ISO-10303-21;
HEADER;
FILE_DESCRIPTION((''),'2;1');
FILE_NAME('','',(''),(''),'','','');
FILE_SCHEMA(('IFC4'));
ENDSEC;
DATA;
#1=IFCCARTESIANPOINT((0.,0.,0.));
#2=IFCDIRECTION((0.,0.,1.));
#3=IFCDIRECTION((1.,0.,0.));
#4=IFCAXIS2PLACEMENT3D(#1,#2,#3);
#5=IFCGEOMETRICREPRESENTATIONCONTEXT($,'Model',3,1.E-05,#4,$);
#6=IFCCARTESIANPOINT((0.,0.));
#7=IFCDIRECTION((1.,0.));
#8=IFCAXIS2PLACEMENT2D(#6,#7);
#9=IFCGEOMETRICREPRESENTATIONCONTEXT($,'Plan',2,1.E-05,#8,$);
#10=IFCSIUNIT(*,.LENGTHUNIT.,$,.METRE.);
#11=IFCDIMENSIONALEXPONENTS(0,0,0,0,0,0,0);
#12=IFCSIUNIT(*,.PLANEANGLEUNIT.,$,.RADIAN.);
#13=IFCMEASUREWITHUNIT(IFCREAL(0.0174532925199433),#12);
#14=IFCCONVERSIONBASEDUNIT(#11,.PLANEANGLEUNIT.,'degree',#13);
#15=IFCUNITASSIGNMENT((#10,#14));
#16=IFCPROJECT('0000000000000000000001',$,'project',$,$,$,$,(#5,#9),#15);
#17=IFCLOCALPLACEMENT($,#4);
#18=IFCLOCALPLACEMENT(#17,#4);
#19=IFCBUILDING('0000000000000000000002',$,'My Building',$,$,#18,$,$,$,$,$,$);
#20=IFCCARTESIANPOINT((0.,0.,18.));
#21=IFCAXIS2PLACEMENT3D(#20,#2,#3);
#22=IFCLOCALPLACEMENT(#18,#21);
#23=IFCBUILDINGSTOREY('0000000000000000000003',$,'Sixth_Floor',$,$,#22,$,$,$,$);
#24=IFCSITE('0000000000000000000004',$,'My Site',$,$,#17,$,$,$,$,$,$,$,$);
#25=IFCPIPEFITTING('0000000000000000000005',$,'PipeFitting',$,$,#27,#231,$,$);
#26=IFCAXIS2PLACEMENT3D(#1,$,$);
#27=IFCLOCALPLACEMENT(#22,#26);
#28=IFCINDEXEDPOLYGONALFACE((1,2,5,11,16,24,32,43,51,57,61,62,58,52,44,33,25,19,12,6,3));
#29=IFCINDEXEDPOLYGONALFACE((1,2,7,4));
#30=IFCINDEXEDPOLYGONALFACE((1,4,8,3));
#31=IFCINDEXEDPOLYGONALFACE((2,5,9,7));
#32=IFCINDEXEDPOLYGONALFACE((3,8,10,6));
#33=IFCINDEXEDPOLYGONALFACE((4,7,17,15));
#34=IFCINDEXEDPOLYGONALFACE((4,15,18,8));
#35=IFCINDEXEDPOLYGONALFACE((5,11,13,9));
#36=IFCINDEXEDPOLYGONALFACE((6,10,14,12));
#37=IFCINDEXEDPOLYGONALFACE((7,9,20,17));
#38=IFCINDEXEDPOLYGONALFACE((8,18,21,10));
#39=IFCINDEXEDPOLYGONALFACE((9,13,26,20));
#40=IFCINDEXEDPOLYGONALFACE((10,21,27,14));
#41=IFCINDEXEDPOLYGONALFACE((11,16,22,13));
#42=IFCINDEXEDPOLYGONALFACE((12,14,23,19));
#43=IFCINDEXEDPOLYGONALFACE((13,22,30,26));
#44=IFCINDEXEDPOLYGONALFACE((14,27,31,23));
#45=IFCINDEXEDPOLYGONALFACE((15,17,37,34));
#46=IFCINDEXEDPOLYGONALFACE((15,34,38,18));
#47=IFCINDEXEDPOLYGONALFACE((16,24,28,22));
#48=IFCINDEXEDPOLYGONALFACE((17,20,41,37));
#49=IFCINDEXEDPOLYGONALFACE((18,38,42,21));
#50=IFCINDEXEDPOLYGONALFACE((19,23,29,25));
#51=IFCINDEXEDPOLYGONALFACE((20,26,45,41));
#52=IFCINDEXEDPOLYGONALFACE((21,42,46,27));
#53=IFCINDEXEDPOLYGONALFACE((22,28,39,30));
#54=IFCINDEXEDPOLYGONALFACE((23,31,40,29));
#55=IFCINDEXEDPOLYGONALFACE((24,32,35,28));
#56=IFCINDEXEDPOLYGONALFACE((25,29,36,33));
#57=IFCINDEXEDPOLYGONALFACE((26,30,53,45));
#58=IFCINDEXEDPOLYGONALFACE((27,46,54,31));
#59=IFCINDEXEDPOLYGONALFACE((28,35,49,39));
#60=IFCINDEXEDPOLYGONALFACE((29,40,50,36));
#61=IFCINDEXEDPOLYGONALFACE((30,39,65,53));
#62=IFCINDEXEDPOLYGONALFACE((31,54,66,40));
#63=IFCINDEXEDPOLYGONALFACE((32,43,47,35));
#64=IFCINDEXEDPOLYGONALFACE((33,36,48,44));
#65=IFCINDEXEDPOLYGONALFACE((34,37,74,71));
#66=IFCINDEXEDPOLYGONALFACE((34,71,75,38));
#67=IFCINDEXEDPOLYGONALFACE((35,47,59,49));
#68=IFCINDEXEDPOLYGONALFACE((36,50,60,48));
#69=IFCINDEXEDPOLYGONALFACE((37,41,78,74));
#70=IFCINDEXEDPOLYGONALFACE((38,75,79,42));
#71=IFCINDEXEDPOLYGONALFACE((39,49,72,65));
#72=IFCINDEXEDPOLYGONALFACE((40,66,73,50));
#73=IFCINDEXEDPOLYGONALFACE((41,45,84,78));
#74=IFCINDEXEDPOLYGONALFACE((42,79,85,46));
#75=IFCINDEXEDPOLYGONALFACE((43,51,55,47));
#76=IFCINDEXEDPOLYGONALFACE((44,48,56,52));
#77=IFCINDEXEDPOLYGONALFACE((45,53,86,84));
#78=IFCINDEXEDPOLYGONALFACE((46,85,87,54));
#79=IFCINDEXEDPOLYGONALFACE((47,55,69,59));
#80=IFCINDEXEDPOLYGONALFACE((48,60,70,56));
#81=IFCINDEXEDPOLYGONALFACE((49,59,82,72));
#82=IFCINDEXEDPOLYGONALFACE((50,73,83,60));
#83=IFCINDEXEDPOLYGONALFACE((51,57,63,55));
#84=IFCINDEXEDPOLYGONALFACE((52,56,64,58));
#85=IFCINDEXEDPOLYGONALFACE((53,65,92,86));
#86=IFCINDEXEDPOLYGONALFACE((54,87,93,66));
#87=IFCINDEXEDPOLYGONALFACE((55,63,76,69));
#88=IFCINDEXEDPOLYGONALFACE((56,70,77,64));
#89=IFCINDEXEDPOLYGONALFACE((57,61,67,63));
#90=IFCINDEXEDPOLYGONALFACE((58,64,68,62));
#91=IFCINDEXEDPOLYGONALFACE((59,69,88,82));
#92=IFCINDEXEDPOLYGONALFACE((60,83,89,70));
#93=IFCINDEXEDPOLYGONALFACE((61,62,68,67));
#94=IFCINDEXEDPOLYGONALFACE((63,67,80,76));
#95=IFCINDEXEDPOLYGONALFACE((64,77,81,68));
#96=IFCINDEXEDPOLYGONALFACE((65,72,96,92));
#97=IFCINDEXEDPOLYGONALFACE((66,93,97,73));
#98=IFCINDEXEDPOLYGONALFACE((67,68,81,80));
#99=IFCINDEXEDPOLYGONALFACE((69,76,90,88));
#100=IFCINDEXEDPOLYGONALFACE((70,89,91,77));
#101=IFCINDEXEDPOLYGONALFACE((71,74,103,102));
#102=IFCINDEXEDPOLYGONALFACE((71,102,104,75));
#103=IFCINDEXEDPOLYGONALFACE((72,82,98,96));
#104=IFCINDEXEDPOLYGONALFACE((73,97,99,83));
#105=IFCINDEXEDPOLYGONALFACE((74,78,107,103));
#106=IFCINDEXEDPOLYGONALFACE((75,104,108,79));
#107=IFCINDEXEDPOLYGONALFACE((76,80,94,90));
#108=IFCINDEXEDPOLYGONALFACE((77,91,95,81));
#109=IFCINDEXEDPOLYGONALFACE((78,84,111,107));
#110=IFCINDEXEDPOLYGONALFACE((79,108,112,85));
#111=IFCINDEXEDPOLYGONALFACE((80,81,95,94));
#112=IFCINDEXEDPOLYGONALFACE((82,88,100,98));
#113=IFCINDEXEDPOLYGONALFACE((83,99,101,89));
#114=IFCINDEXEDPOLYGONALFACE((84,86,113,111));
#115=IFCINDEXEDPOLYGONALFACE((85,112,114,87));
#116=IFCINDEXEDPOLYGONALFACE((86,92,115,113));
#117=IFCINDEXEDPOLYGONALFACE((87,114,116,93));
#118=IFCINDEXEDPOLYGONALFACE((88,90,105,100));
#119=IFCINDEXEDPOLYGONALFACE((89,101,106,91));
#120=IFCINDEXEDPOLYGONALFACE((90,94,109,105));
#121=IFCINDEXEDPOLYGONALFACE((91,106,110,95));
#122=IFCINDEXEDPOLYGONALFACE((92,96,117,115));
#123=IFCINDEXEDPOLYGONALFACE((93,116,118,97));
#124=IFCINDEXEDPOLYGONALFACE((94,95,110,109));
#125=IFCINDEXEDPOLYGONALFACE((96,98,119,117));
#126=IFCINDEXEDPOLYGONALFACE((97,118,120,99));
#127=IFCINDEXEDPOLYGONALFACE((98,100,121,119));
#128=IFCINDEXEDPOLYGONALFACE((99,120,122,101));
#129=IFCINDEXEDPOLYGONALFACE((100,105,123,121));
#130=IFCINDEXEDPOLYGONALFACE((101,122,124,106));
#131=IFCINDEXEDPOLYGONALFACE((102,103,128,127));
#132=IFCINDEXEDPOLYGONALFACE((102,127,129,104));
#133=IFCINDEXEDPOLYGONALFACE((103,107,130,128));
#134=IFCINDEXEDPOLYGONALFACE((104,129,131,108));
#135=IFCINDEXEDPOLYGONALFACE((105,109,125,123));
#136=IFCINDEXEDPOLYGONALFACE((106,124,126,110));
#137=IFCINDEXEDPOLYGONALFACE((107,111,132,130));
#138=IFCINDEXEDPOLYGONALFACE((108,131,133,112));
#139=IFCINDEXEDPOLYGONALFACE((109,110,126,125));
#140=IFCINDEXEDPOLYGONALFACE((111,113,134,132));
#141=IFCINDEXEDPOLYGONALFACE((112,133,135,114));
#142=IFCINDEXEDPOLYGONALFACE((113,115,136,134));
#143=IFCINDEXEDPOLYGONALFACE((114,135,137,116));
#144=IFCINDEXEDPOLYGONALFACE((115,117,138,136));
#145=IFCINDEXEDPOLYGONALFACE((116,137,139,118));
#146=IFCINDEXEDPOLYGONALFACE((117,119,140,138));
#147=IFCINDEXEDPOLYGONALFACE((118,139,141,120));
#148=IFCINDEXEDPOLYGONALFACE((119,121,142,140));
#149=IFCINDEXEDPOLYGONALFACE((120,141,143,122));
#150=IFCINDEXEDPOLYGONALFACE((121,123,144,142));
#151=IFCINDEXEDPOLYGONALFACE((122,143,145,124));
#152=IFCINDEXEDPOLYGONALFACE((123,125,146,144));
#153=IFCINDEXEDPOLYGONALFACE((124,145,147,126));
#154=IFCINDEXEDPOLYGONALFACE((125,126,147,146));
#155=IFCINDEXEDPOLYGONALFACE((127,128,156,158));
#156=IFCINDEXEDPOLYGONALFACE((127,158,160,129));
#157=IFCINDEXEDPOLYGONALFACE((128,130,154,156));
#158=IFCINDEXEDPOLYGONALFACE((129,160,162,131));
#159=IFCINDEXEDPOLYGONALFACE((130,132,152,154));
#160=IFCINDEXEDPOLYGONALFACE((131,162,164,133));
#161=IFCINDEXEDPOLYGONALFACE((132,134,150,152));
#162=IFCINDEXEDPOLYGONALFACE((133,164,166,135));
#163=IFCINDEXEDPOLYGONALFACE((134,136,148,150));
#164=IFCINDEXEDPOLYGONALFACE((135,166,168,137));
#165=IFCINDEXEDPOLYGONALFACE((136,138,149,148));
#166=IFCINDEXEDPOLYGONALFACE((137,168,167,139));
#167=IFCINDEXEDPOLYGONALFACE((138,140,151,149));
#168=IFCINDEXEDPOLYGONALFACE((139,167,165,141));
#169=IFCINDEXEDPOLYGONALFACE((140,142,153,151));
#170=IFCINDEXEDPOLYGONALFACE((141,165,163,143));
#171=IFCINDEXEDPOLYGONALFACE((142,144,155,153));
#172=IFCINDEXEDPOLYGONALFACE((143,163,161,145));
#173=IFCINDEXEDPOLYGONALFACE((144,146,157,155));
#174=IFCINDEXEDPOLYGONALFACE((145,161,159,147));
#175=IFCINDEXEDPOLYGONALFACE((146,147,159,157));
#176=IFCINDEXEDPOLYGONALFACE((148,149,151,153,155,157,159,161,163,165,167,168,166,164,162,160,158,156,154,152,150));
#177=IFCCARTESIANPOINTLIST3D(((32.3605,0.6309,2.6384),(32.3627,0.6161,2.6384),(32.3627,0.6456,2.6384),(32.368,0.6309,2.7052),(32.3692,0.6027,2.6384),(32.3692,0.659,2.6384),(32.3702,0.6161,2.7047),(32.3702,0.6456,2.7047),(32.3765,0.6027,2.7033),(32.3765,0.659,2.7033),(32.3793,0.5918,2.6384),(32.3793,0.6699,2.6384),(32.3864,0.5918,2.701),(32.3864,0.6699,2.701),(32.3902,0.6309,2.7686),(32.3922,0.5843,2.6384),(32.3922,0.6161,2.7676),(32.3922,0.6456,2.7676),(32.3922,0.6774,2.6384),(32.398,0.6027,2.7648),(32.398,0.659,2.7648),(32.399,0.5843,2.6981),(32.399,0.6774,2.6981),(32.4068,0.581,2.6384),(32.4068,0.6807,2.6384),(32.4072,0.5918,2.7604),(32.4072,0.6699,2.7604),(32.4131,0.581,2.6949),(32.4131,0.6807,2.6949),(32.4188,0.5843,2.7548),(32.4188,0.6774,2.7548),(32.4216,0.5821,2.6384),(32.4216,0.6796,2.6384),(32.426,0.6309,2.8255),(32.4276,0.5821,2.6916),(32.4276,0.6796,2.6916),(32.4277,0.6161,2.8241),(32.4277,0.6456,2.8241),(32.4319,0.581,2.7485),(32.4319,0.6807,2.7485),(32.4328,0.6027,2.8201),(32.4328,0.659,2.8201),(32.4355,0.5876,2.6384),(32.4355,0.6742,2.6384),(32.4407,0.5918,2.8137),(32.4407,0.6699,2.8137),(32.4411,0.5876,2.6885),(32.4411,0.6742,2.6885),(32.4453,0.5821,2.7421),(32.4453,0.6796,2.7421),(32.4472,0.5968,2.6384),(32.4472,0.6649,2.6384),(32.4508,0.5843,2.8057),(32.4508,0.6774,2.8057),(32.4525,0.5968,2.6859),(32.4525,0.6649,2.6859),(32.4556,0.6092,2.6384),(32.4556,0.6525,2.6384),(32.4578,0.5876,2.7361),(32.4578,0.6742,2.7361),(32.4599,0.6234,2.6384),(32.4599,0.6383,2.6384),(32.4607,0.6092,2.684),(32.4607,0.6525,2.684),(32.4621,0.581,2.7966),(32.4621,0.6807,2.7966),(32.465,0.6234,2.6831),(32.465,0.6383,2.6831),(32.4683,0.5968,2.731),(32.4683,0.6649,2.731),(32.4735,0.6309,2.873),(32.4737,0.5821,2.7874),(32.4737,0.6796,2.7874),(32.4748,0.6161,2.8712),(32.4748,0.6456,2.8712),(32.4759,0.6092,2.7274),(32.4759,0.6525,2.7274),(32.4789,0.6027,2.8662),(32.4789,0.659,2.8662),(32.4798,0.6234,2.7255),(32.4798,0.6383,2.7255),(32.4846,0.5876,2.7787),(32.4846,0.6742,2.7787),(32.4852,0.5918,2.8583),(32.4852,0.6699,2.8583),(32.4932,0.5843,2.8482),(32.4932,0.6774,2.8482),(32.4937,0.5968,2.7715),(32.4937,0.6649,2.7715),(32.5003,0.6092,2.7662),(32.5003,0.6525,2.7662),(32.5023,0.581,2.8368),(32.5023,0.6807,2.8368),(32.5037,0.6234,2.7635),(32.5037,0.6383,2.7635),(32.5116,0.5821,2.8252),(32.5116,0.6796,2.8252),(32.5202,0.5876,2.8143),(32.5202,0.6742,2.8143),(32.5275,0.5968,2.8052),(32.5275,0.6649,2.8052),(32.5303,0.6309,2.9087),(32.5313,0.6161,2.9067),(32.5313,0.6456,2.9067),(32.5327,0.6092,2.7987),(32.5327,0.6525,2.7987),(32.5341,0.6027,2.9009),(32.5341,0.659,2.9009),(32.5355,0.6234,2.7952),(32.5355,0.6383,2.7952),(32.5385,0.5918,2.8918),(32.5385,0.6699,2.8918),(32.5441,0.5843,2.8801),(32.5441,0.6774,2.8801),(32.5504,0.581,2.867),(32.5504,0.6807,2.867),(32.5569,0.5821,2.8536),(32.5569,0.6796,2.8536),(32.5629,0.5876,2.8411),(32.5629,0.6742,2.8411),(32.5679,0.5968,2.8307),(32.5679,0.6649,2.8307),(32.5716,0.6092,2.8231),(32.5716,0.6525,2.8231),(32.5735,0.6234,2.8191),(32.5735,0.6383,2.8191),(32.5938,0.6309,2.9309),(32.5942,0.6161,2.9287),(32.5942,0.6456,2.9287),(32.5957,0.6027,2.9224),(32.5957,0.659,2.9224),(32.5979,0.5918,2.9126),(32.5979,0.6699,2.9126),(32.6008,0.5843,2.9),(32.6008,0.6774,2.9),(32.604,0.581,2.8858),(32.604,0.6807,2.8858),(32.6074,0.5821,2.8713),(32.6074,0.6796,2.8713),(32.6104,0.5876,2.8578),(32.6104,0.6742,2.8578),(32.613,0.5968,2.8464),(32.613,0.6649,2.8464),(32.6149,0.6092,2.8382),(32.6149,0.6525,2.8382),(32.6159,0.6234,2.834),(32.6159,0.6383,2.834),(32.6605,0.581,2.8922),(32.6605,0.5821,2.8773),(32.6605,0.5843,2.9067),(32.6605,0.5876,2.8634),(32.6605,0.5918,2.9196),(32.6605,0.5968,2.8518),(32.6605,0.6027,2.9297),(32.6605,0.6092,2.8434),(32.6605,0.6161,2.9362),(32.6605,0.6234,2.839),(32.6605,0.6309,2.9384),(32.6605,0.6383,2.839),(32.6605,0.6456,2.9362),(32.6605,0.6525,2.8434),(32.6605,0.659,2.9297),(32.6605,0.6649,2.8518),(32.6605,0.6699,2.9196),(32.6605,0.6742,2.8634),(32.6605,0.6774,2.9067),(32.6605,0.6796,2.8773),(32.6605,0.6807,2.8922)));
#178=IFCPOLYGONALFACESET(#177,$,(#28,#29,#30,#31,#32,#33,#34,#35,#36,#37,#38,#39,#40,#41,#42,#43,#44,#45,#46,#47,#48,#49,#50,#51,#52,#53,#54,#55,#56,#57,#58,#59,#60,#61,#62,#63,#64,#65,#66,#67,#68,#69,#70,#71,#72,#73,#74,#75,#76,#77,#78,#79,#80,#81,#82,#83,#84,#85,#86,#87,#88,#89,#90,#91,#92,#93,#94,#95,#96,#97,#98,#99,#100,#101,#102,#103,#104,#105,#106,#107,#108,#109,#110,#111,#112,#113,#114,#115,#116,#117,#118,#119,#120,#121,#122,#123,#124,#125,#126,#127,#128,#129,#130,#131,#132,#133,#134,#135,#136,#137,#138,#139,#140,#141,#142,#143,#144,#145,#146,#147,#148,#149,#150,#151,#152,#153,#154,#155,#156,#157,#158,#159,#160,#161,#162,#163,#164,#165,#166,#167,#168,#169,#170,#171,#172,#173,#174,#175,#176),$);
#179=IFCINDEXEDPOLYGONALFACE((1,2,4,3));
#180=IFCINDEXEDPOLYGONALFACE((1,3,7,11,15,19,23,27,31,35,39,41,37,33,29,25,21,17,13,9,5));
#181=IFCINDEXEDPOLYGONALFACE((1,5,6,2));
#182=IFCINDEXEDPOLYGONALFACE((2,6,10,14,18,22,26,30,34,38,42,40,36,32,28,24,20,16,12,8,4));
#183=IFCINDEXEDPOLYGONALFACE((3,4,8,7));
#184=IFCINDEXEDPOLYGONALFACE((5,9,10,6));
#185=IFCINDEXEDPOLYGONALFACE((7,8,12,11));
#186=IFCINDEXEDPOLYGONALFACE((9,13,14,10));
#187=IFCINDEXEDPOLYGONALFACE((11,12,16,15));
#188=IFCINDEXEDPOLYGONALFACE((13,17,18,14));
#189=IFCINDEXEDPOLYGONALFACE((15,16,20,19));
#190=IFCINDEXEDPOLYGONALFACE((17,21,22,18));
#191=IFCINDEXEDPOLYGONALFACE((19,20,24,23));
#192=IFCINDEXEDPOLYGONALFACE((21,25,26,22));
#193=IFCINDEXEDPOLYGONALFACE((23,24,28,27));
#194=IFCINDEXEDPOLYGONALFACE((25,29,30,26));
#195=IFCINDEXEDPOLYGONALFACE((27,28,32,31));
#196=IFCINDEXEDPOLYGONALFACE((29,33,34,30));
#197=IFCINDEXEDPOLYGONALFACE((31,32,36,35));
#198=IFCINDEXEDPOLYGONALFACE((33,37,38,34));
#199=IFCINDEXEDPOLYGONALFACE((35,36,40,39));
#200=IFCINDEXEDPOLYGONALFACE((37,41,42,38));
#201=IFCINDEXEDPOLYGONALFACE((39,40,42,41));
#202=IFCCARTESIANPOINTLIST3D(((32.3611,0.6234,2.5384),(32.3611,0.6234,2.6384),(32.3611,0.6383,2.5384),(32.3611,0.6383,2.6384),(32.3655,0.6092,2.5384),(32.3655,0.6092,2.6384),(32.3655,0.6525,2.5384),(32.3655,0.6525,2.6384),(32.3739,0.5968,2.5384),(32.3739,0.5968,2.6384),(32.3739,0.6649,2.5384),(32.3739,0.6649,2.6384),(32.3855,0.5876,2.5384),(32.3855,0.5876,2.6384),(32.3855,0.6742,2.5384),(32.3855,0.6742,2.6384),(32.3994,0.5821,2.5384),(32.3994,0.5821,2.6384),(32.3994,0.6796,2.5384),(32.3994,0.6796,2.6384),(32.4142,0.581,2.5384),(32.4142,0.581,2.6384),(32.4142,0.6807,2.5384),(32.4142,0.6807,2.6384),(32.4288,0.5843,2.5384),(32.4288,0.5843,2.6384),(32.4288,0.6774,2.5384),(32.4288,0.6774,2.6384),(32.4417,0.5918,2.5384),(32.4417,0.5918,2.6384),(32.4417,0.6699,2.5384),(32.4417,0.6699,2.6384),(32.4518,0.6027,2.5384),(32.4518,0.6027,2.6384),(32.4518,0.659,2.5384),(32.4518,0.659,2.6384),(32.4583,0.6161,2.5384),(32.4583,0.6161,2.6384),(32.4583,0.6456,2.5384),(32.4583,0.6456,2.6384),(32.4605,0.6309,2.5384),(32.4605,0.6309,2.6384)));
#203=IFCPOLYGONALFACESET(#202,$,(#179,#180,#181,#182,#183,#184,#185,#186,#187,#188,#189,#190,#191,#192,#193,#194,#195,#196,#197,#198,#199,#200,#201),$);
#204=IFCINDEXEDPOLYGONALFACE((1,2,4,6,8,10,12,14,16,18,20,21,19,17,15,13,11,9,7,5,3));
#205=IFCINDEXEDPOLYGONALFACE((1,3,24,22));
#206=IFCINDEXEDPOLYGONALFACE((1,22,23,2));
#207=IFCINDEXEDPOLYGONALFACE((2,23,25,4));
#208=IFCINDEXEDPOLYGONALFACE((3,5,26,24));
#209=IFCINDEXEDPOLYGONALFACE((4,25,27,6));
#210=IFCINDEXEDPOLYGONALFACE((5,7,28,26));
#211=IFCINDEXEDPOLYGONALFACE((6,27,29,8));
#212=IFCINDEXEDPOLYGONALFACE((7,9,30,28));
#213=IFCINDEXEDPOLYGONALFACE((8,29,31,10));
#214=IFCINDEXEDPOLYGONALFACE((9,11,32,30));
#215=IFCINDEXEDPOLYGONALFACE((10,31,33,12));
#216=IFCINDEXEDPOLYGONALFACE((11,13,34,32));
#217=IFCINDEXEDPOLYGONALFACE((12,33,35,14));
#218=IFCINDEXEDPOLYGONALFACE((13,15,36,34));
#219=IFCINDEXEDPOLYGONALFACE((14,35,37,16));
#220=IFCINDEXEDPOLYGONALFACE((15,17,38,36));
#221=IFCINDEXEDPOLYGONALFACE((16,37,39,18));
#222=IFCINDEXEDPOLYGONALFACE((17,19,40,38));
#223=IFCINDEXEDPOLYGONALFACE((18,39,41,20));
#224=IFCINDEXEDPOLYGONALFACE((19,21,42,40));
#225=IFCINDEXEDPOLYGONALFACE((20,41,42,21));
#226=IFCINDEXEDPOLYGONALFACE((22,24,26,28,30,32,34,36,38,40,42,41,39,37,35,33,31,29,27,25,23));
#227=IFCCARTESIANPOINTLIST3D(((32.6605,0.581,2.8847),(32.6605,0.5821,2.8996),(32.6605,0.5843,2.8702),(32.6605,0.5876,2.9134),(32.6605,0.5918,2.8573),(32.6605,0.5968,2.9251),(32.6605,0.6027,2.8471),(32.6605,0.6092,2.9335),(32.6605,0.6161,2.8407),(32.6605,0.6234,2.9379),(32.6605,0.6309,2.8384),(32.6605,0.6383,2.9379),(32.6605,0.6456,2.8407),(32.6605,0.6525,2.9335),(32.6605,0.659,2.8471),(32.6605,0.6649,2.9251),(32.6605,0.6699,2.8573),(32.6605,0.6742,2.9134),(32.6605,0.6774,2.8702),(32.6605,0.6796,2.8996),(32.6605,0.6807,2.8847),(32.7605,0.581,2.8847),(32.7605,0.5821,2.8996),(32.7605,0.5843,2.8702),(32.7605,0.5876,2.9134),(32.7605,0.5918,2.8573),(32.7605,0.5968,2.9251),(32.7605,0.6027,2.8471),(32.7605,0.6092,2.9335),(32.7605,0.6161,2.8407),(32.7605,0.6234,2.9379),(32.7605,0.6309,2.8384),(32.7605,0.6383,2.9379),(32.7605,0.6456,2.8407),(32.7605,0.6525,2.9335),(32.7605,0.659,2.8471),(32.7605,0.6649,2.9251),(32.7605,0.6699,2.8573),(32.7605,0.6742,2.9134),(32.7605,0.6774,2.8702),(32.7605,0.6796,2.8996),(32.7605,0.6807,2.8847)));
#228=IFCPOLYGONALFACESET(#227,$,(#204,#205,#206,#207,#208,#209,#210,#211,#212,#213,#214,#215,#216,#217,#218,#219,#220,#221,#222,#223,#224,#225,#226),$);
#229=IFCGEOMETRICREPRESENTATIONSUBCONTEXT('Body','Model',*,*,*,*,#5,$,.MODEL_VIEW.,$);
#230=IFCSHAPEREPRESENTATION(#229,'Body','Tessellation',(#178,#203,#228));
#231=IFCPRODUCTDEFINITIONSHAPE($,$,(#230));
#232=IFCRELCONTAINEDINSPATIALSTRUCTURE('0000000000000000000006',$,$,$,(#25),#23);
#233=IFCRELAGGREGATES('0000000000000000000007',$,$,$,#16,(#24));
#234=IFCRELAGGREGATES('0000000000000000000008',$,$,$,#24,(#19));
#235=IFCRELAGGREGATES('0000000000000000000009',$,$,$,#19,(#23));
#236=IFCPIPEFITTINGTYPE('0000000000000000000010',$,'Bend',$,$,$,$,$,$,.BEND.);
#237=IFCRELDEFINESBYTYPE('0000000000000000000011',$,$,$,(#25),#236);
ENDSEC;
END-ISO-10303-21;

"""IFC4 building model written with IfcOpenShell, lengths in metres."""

from ifc_helpers import new_model, entity, si_unit, converted_unit, frame, origin_with_axes, origin_2d_with_axis, place, context, subcontext, project, spatial, circle, extrude, source, transform, mapped, type_object, type_shapes, element, save


model = new_model("IFC4")

# Units and contexts
model_context = context("Model", 3, precision=1e-05, world=origin_with_axes())
plan_context = context("Plan", 2, precision=1e-05, world=origin_2d_with_axis())
body_context = subcontext(model_context, "Body", "Model", "MODEL_VIEW")
ifc_project = project(units=[si_unit("LENGTHUNIT", "METRE"), converted_unit("PLANEANGLEUNIT", "degree", entity("IfcReal", 0.0174532925199433), si_unit("PLANEANGLEUNIT", "RADIAN"), dimensions=[0, 0, 0, 0, 0, 0, 0])], contexts=[model_context, plan_context])

# Site, building, storey
site_placement = place(None, origin_with_axes())
site = spatial("IfcSite", under=ifc_project, at=site_placement, Name="My Site")
building_placement = place(site_placement, origin_with_axes())
building = spatial("IfcBuilding", under=site, at=building_placement, Name="My Building")
storey_placement = place(building_placement, frame((0.0, 0.0, 18.0), z_axis=(0.0, 0.0, 1.0), x_axis=(1.0, 0.0, 0.0)))
storey = spatial("IfcBuildingStorey", under=building, at=storey_placement, Name="Sixth_Floor")

# Pipe fitting
pipe_fitting_type = type_object("IfcPipeFittingType", Name="Bend", PredefinedType="BEND")
shared_shape = source(origin_with_axes(), body_context, "Body", "SolidModel", [
    entity("IfcSweptDiskSolid", entity("IfcIndexedPolyCurve", entity("IfcCartesianPointList3D", [[0.0, 0.0, -0.1], [0.0732, 0.0, -0.2768], [0.25, 0.0, -0.35]]), [entity("IfcArcIndex", [1, 2, 3])]), 0.05),
    extrude(circle(Radius=0.05), origin_with_axes(), (0.0, 0.0, -1.0), 0.1),
    extrude(circle(Radius=0.05), frame((0.25, 0.0, -0.35), z_axis=(1.0, 0.0, 0.0), x_axis=(0.0, 0.0, 1.0)), (0.0, 0.0, 1.0), 0.1),
])
type_shapes(pipe_fitting_type, [shared_shape])
for number, where, z_axis, x_axis, name in (
    (1, (32.4105, 0.6309, 2.5384), (0.0, 0.0, -1.0), (1.0, 0.000001, 0.0), "PipeFitting"),
):
    element("IfcPipeFitting", number, at=place(storey_placement, frame(where, z_axis=z_axis, x_axis=x_axis)), inside=storey, type_object=pipe_fitting_type, Name=name, context=body_context, shape_type="MappedRepresentation", body=[
        mapped(shared_shape, transform((0.0, 0.0, 0.0), x_axis=(1.0, 0.0, 0.0), y_axis=(0.0, 1.0, 0.0), z_axis=(0.0, 0.0, 1.0), scale=1.0)),
    ])

save(model, "model.ifc")
